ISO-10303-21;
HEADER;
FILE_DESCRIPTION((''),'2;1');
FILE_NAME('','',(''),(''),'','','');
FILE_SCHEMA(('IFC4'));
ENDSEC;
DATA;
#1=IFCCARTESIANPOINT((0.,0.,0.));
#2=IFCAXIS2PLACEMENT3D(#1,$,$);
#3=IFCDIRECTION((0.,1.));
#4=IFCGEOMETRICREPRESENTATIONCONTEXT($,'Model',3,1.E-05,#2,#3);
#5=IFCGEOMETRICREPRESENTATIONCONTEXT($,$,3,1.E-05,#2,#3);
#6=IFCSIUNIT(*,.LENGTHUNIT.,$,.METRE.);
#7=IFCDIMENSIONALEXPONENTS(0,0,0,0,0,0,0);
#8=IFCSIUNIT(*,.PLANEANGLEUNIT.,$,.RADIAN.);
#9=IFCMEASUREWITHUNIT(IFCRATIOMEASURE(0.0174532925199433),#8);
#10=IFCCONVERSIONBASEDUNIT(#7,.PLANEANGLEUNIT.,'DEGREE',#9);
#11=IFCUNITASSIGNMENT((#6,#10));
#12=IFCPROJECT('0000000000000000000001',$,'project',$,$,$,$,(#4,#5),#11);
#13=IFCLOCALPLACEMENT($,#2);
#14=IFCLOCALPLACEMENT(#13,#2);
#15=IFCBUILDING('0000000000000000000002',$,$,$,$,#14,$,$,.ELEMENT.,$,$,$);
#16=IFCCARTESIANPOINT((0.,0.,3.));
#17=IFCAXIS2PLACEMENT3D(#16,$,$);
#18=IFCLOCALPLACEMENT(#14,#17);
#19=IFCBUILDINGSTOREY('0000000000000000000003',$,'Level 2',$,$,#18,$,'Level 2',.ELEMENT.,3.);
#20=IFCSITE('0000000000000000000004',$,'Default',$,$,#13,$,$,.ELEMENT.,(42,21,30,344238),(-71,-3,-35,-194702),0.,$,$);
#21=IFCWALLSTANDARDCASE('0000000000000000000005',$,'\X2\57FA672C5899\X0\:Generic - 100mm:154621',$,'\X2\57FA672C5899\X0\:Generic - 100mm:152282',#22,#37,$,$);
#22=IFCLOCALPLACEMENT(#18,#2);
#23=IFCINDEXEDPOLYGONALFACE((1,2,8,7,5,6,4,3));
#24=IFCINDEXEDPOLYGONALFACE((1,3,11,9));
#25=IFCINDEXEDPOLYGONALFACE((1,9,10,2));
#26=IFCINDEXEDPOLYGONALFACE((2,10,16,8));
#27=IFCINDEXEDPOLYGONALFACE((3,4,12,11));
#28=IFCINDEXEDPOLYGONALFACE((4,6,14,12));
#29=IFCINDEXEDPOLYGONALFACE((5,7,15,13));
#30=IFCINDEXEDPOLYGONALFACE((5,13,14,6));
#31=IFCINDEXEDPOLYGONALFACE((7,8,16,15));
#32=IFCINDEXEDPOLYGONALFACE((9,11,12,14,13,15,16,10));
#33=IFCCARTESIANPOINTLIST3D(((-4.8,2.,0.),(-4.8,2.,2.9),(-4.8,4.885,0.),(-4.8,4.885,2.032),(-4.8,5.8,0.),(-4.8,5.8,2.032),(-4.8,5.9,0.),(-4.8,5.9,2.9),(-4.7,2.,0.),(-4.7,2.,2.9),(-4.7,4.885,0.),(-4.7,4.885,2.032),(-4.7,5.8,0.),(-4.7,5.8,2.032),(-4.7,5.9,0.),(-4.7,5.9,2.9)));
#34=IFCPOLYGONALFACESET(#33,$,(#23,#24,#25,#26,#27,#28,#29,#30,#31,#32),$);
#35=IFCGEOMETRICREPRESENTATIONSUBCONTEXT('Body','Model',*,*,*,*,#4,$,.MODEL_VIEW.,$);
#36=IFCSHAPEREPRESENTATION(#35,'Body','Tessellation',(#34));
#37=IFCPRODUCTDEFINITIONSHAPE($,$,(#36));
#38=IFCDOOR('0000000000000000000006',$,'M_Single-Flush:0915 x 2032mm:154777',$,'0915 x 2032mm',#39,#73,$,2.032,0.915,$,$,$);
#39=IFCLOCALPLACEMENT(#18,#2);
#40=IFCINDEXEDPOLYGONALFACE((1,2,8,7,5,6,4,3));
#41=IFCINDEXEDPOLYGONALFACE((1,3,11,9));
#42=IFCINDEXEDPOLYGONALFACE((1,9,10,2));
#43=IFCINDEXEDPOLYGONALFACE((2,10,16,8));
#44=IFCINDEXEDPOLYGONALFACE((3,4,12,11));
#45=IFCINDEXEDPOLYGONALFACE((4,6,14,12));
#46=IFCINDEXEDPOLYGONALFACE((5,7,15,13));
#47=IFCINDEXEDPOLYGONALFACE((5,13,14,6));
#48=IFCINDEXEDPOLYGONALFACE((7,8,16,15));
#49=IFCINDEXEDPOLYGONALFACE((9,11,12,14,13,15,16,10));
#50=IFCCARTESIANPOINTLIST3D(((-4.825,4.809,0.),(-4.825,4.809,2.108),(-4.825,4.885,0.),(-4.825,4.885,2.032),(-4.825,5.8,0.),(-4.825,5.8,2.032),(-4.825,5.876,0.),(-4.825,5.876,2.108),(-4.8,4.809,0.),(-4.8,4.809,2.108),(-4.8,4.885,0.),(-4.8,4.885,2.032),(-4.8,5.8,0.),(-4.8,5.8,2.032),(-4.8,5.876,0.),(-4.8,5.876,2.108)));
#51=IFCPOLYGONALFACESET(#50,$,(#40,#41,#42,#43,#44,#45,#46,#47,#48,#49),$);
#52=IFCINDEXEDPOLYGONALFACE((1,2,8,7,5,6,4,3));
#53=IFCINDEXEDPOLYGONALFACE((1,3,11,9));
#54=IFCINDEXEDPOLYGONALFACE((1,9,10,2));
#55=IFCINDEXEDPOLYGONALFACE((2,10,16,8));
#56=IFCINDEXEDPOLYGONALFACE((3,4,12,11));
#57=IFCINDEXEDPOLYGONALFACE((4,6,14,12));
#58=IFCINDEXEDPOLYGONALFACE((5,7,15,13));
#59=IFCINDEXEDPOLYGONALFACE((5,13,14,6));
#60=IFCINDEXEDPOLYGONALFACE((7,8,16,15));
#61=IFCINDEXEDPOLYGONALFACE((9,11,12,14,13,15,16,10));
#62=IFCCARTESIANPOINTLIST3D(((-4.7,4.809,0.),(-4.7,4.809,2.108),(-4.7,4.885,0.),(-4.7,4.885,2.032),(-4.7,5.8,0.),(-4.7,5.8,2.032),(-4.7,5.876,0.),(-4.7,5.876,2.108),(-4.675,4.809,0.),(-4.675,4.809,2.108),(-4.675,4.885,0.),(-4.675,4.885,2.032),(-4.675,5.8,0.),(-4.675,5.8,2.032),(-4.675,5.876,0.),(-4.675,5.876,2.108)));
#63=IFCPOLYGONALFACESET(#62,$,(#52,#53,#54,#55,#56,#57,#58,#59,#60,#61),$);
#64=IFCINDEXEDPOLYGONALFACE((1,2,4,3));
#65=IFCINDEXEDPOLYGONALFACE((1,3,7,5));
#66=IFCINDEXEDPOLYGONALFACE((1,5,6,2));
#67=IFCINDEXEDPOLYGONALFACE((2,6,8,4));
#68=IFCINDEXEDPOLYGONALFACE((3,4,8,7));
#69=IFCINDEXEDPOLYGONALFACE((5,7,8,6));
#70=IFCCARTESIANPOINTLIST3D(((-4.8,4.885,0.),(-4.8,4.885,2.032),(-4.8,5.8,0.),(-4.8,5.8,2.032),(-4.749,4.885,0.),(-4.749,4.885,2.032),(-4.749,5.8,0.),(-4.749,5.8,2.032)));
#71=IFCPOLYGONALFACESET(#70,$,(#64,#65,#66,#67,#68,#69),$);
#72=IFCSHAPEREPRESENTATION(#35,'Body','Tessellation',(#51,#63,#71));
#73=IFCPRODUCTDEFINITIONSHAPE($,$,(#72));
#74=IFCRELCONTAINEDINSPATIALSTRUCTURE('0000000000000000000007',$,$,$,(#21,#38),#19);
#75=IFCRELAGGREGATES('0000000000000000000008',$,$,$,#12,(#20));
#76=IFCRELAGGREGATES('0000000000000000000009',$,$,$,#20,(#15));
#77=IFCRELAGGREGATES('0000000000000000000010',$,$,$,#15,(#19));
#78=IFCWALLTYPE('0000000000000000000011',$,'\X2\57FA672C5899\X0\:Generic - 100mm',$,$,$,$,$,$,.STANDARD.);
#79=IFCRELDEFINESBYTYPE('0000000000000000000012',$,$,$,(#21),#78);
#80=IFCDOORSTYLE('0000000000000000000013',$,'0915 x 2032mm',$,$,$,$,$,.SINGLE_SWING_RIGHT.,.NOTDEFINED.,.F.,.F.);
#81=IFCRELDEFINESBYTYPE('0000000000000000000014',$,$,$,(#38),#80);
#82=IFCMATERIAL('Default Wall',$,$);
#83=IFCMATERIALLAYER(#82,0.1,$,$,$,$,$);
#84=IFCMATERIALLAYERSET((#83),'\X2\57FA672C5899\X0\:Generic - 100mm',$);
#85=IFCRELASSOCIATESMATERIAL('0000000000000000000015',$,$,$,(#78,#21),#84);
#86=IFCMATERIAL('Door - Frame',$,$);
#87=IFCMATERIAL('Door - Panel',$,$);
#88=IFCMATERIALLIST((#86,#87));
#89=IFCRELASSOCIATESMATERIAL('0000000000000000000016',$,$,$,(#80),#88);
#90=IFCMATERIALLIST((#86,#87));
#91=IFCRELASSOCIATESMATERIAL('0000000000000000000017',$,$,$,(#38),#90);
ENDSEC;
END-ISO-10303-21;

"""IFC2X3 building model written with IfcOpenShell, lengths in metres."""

from ifc_helpers import new_model, entity, si_unit, converted_unit, direction, frame, frame_2d, origin, origin_2d_with_axis, place, context, subcontext, project, spatial, polyline, rectangle, outline, extrude, clip, bounded_halfspace, source, transform, mapped, material, material_list, layer, layer_set, layer_usage, type_object, type_shapes, element, fill, save


model = new_model("IFC2X3")

# Units and contexts
model_context = context("Model", 3, precision=1e-05, world=origin(), true_north=direction((0.0, 1.0)))
context_of_model = context(None, 3, precision=1e-05, world=origin(), true_north=direction((0.0, 1.0)))
body_context = subcontext(model_context, "Body", "Model", "MODEL_VIEW")
ifc_project = project(units=[si_unit("LENGTHUNIT", "METRE"), converted_unit("PLANEANGLEUNIT", "DEGREE", entity("IfcRatioMeasure", 0.0174532925199433), si_unit("PLANEANGLEUNIT", "RADIAN"), dimensions=[0, 0, 0, 0, 0, 0, 0])], contexts=[model_context, context_of_model])

# Site, building, storey
site_placement = place(None, origin())
site = spatial("IfcSite", under=ifc_project, at=site_placement, Name="Default", CompositionType="ELEMENT", RefLatitude=(42, 21, 30, 344238), RefLongitude=(-71, -3, -35, -194702), RefElevation=0.0)
building_placement = place(site_placement, origin())
building = spatial("IfcBuilding", under=site, at=building_placement, CompositionType="ELEMENT")
storey_placement = place(building_placement, frame((0.0, 0.0, 3.0)))
storey = spatial("IfcBuildingStorey", under=building, at=storey_placement, Name="Level 2", LongName="Level 2", CompositionType="ELEMENT", Elevation=3.0)

# Shared definitions
ifc_material_1 = material(Name="Default Wall")

# Shared definitions
ifc_layer_1 = layer(ifc_material_1, 0.1)
ifc_layer_set_1 = layer_set([ifc_layer_1], Name="基本墙:Generic - 100mm")
wall_type_1 = type_object("IfcWallType", Name="基本墙:Generic - 100mm", PredefinedType="STANDARD", material=ifc_layer_set_1)
ifc_material_2 = material(Name="Door - Panel")
ifc_material_3 = material(Name="Door - Frame")

# Wall, opening, door
ifc_layer_usage_1 = layer_usage(ifc_layer_set_1, "AXIS2", "NEGATIVE", 0.05)
wall_1_placement = place(storey_placement, frame((-4.75, 2.0, 0.0), z_axis=(0.0, 0.0, 1.0), x_axis=(0.0, 1.0, 0.0)))
wall_1 = element("IfcWallStandardCase", 1, at=wall_1_placement, inside=storey, type_object=wall_type_1, material=ifc_layer_usage_1, Name="基本墙:Generic - 100mm:154621", ObjectType="基本墙:Generic - 100mm:152282", context=body_context, shape_type="Clipping", body=[
    clip(extrude(rectangle(XDim=3.9, YDim=0.1, at=frame_2d((1.95, 0.0), x_axis=(-1.0, 0.0))), origin(), (0.0, 0.0, 1.0), 3.2), bounded_halfspace(frame((0.0, -0.05, 2.9), z_axis=(0.0, 0.0, -1.0), x_axis=(-1.0, 0.0, 0.0)), True, frame((0.0, -0.05, 2.9), z_axis=(0.0, 0.0, -1.0), x_axis=(-1.0, 0.0, 0.0)), polyline([(0.0, 0.0), (0.0, 0.1), (-3.9, 0.1), (-3.9, 0.0), (0.0, 0.0)]))),
])
opening_1_placement = place(wall_1_placement, frame((2.885, -0.05, 0.0)))
opening_1 = element("IfcOpeningElement", 2, at=opening_1_placement, cuts=wall_1, ObjectType="Opening", context=body_context, shape_type="SweptSolid", body=[
    extrude(rectangle(XDim=0.915, YDim=2.032, at=frame_2d((1.016, 0.4575), x_axis=(0.0, 1.0))), frame((0.0, 0.0, 0.0), z_axis=(0.0, 1.0, 0.0), x_axis=(0.0, 0.0, 1.0)), (0.0, 0.0, 1.0), 0.1),
])
ifc_material_list_1 = material_list([ifc_material_3, ifc_material_2])
ifc_material_list_2 = material_list([ifc_material_3, ifc_material_2])
door_style_1 = type_object("IfcDoorStyle", Name="0915 x 2032mm", ConstructionType="NOTDEFINED", OperationType="SINGLE_SWING_RIGHT", ParameterTakesPrecedence=False, Sizeable=False, material=ifc_material_list_2)
shared_shape_1 = source(origin(), body_context, "Body", "SweptSolid", [
    extrude(outline(polyline([(-0.5335, -1.073), (0.5335, -1.073), (0.5335, 1.035), (0.4575, 1.035), (0.4575, -0.997), (-0.4575, -0.997), (-0.4575, 1.035), (-0.5335, 1.035), (-0.5335, -1.073)])), frame((0.4575, 0.1, 1.035), z_axis=(0.0, 1.0, 0.0), x_axis=(1.0, 0.0, 0.0)), (0.0, 0.0, 1.0), 0.025),
    extrude(outline(polyline([(-1.073, -0.5335), (1.035, -0.5335), (1.035, -0.4575), (-0.997, -0.4575), (-0.997, 0.4575), (1.035, 0.4575), (1.035, 0.5335), (-1.073, 0.5335), (-1.073, -0.5335)])), frame((0.4575, -0.025, 1.035), z_axis=(0.0, 1.0, 0.0), x_axis=(0.0, 0.0, -1.0)), (0.0, 0.0, 1.0), 0.025),
    extrude(rectangle(XDim=0.051, YDim=0.915, at=origin_2d_with_axis()), frame((0.4575, 0.0745, 0.0), z_axis=(0.0, 0.0, 1.0), x_axis=(0.0, 1.0, 0.0)), (0.0, 0.0, 1.0), 2.032),
])
type_shapes(door_style_1, [shared_shape_1])
door_1_placement = place(opening_1_placement, origin())
door_1 = element("IfcDoor", 3, at=door_1_placement, inside=storey, type_object=door_style_1, material=ifc_material_list_1, Name="M_Single-Flush:0915 x 2032mm:154777", ObjectType="0915 x 2032mm", OverallHeight=2.032, OverallWidth=0.915, context=body_context, shape_type="MappedRepresentation", body=[
    mapped(shared_shape_1, transform((0.0, 0.0, 0.0), scale=1.0)),
])
fill(opening_1, door_1)

save(model, "model.ifc")
